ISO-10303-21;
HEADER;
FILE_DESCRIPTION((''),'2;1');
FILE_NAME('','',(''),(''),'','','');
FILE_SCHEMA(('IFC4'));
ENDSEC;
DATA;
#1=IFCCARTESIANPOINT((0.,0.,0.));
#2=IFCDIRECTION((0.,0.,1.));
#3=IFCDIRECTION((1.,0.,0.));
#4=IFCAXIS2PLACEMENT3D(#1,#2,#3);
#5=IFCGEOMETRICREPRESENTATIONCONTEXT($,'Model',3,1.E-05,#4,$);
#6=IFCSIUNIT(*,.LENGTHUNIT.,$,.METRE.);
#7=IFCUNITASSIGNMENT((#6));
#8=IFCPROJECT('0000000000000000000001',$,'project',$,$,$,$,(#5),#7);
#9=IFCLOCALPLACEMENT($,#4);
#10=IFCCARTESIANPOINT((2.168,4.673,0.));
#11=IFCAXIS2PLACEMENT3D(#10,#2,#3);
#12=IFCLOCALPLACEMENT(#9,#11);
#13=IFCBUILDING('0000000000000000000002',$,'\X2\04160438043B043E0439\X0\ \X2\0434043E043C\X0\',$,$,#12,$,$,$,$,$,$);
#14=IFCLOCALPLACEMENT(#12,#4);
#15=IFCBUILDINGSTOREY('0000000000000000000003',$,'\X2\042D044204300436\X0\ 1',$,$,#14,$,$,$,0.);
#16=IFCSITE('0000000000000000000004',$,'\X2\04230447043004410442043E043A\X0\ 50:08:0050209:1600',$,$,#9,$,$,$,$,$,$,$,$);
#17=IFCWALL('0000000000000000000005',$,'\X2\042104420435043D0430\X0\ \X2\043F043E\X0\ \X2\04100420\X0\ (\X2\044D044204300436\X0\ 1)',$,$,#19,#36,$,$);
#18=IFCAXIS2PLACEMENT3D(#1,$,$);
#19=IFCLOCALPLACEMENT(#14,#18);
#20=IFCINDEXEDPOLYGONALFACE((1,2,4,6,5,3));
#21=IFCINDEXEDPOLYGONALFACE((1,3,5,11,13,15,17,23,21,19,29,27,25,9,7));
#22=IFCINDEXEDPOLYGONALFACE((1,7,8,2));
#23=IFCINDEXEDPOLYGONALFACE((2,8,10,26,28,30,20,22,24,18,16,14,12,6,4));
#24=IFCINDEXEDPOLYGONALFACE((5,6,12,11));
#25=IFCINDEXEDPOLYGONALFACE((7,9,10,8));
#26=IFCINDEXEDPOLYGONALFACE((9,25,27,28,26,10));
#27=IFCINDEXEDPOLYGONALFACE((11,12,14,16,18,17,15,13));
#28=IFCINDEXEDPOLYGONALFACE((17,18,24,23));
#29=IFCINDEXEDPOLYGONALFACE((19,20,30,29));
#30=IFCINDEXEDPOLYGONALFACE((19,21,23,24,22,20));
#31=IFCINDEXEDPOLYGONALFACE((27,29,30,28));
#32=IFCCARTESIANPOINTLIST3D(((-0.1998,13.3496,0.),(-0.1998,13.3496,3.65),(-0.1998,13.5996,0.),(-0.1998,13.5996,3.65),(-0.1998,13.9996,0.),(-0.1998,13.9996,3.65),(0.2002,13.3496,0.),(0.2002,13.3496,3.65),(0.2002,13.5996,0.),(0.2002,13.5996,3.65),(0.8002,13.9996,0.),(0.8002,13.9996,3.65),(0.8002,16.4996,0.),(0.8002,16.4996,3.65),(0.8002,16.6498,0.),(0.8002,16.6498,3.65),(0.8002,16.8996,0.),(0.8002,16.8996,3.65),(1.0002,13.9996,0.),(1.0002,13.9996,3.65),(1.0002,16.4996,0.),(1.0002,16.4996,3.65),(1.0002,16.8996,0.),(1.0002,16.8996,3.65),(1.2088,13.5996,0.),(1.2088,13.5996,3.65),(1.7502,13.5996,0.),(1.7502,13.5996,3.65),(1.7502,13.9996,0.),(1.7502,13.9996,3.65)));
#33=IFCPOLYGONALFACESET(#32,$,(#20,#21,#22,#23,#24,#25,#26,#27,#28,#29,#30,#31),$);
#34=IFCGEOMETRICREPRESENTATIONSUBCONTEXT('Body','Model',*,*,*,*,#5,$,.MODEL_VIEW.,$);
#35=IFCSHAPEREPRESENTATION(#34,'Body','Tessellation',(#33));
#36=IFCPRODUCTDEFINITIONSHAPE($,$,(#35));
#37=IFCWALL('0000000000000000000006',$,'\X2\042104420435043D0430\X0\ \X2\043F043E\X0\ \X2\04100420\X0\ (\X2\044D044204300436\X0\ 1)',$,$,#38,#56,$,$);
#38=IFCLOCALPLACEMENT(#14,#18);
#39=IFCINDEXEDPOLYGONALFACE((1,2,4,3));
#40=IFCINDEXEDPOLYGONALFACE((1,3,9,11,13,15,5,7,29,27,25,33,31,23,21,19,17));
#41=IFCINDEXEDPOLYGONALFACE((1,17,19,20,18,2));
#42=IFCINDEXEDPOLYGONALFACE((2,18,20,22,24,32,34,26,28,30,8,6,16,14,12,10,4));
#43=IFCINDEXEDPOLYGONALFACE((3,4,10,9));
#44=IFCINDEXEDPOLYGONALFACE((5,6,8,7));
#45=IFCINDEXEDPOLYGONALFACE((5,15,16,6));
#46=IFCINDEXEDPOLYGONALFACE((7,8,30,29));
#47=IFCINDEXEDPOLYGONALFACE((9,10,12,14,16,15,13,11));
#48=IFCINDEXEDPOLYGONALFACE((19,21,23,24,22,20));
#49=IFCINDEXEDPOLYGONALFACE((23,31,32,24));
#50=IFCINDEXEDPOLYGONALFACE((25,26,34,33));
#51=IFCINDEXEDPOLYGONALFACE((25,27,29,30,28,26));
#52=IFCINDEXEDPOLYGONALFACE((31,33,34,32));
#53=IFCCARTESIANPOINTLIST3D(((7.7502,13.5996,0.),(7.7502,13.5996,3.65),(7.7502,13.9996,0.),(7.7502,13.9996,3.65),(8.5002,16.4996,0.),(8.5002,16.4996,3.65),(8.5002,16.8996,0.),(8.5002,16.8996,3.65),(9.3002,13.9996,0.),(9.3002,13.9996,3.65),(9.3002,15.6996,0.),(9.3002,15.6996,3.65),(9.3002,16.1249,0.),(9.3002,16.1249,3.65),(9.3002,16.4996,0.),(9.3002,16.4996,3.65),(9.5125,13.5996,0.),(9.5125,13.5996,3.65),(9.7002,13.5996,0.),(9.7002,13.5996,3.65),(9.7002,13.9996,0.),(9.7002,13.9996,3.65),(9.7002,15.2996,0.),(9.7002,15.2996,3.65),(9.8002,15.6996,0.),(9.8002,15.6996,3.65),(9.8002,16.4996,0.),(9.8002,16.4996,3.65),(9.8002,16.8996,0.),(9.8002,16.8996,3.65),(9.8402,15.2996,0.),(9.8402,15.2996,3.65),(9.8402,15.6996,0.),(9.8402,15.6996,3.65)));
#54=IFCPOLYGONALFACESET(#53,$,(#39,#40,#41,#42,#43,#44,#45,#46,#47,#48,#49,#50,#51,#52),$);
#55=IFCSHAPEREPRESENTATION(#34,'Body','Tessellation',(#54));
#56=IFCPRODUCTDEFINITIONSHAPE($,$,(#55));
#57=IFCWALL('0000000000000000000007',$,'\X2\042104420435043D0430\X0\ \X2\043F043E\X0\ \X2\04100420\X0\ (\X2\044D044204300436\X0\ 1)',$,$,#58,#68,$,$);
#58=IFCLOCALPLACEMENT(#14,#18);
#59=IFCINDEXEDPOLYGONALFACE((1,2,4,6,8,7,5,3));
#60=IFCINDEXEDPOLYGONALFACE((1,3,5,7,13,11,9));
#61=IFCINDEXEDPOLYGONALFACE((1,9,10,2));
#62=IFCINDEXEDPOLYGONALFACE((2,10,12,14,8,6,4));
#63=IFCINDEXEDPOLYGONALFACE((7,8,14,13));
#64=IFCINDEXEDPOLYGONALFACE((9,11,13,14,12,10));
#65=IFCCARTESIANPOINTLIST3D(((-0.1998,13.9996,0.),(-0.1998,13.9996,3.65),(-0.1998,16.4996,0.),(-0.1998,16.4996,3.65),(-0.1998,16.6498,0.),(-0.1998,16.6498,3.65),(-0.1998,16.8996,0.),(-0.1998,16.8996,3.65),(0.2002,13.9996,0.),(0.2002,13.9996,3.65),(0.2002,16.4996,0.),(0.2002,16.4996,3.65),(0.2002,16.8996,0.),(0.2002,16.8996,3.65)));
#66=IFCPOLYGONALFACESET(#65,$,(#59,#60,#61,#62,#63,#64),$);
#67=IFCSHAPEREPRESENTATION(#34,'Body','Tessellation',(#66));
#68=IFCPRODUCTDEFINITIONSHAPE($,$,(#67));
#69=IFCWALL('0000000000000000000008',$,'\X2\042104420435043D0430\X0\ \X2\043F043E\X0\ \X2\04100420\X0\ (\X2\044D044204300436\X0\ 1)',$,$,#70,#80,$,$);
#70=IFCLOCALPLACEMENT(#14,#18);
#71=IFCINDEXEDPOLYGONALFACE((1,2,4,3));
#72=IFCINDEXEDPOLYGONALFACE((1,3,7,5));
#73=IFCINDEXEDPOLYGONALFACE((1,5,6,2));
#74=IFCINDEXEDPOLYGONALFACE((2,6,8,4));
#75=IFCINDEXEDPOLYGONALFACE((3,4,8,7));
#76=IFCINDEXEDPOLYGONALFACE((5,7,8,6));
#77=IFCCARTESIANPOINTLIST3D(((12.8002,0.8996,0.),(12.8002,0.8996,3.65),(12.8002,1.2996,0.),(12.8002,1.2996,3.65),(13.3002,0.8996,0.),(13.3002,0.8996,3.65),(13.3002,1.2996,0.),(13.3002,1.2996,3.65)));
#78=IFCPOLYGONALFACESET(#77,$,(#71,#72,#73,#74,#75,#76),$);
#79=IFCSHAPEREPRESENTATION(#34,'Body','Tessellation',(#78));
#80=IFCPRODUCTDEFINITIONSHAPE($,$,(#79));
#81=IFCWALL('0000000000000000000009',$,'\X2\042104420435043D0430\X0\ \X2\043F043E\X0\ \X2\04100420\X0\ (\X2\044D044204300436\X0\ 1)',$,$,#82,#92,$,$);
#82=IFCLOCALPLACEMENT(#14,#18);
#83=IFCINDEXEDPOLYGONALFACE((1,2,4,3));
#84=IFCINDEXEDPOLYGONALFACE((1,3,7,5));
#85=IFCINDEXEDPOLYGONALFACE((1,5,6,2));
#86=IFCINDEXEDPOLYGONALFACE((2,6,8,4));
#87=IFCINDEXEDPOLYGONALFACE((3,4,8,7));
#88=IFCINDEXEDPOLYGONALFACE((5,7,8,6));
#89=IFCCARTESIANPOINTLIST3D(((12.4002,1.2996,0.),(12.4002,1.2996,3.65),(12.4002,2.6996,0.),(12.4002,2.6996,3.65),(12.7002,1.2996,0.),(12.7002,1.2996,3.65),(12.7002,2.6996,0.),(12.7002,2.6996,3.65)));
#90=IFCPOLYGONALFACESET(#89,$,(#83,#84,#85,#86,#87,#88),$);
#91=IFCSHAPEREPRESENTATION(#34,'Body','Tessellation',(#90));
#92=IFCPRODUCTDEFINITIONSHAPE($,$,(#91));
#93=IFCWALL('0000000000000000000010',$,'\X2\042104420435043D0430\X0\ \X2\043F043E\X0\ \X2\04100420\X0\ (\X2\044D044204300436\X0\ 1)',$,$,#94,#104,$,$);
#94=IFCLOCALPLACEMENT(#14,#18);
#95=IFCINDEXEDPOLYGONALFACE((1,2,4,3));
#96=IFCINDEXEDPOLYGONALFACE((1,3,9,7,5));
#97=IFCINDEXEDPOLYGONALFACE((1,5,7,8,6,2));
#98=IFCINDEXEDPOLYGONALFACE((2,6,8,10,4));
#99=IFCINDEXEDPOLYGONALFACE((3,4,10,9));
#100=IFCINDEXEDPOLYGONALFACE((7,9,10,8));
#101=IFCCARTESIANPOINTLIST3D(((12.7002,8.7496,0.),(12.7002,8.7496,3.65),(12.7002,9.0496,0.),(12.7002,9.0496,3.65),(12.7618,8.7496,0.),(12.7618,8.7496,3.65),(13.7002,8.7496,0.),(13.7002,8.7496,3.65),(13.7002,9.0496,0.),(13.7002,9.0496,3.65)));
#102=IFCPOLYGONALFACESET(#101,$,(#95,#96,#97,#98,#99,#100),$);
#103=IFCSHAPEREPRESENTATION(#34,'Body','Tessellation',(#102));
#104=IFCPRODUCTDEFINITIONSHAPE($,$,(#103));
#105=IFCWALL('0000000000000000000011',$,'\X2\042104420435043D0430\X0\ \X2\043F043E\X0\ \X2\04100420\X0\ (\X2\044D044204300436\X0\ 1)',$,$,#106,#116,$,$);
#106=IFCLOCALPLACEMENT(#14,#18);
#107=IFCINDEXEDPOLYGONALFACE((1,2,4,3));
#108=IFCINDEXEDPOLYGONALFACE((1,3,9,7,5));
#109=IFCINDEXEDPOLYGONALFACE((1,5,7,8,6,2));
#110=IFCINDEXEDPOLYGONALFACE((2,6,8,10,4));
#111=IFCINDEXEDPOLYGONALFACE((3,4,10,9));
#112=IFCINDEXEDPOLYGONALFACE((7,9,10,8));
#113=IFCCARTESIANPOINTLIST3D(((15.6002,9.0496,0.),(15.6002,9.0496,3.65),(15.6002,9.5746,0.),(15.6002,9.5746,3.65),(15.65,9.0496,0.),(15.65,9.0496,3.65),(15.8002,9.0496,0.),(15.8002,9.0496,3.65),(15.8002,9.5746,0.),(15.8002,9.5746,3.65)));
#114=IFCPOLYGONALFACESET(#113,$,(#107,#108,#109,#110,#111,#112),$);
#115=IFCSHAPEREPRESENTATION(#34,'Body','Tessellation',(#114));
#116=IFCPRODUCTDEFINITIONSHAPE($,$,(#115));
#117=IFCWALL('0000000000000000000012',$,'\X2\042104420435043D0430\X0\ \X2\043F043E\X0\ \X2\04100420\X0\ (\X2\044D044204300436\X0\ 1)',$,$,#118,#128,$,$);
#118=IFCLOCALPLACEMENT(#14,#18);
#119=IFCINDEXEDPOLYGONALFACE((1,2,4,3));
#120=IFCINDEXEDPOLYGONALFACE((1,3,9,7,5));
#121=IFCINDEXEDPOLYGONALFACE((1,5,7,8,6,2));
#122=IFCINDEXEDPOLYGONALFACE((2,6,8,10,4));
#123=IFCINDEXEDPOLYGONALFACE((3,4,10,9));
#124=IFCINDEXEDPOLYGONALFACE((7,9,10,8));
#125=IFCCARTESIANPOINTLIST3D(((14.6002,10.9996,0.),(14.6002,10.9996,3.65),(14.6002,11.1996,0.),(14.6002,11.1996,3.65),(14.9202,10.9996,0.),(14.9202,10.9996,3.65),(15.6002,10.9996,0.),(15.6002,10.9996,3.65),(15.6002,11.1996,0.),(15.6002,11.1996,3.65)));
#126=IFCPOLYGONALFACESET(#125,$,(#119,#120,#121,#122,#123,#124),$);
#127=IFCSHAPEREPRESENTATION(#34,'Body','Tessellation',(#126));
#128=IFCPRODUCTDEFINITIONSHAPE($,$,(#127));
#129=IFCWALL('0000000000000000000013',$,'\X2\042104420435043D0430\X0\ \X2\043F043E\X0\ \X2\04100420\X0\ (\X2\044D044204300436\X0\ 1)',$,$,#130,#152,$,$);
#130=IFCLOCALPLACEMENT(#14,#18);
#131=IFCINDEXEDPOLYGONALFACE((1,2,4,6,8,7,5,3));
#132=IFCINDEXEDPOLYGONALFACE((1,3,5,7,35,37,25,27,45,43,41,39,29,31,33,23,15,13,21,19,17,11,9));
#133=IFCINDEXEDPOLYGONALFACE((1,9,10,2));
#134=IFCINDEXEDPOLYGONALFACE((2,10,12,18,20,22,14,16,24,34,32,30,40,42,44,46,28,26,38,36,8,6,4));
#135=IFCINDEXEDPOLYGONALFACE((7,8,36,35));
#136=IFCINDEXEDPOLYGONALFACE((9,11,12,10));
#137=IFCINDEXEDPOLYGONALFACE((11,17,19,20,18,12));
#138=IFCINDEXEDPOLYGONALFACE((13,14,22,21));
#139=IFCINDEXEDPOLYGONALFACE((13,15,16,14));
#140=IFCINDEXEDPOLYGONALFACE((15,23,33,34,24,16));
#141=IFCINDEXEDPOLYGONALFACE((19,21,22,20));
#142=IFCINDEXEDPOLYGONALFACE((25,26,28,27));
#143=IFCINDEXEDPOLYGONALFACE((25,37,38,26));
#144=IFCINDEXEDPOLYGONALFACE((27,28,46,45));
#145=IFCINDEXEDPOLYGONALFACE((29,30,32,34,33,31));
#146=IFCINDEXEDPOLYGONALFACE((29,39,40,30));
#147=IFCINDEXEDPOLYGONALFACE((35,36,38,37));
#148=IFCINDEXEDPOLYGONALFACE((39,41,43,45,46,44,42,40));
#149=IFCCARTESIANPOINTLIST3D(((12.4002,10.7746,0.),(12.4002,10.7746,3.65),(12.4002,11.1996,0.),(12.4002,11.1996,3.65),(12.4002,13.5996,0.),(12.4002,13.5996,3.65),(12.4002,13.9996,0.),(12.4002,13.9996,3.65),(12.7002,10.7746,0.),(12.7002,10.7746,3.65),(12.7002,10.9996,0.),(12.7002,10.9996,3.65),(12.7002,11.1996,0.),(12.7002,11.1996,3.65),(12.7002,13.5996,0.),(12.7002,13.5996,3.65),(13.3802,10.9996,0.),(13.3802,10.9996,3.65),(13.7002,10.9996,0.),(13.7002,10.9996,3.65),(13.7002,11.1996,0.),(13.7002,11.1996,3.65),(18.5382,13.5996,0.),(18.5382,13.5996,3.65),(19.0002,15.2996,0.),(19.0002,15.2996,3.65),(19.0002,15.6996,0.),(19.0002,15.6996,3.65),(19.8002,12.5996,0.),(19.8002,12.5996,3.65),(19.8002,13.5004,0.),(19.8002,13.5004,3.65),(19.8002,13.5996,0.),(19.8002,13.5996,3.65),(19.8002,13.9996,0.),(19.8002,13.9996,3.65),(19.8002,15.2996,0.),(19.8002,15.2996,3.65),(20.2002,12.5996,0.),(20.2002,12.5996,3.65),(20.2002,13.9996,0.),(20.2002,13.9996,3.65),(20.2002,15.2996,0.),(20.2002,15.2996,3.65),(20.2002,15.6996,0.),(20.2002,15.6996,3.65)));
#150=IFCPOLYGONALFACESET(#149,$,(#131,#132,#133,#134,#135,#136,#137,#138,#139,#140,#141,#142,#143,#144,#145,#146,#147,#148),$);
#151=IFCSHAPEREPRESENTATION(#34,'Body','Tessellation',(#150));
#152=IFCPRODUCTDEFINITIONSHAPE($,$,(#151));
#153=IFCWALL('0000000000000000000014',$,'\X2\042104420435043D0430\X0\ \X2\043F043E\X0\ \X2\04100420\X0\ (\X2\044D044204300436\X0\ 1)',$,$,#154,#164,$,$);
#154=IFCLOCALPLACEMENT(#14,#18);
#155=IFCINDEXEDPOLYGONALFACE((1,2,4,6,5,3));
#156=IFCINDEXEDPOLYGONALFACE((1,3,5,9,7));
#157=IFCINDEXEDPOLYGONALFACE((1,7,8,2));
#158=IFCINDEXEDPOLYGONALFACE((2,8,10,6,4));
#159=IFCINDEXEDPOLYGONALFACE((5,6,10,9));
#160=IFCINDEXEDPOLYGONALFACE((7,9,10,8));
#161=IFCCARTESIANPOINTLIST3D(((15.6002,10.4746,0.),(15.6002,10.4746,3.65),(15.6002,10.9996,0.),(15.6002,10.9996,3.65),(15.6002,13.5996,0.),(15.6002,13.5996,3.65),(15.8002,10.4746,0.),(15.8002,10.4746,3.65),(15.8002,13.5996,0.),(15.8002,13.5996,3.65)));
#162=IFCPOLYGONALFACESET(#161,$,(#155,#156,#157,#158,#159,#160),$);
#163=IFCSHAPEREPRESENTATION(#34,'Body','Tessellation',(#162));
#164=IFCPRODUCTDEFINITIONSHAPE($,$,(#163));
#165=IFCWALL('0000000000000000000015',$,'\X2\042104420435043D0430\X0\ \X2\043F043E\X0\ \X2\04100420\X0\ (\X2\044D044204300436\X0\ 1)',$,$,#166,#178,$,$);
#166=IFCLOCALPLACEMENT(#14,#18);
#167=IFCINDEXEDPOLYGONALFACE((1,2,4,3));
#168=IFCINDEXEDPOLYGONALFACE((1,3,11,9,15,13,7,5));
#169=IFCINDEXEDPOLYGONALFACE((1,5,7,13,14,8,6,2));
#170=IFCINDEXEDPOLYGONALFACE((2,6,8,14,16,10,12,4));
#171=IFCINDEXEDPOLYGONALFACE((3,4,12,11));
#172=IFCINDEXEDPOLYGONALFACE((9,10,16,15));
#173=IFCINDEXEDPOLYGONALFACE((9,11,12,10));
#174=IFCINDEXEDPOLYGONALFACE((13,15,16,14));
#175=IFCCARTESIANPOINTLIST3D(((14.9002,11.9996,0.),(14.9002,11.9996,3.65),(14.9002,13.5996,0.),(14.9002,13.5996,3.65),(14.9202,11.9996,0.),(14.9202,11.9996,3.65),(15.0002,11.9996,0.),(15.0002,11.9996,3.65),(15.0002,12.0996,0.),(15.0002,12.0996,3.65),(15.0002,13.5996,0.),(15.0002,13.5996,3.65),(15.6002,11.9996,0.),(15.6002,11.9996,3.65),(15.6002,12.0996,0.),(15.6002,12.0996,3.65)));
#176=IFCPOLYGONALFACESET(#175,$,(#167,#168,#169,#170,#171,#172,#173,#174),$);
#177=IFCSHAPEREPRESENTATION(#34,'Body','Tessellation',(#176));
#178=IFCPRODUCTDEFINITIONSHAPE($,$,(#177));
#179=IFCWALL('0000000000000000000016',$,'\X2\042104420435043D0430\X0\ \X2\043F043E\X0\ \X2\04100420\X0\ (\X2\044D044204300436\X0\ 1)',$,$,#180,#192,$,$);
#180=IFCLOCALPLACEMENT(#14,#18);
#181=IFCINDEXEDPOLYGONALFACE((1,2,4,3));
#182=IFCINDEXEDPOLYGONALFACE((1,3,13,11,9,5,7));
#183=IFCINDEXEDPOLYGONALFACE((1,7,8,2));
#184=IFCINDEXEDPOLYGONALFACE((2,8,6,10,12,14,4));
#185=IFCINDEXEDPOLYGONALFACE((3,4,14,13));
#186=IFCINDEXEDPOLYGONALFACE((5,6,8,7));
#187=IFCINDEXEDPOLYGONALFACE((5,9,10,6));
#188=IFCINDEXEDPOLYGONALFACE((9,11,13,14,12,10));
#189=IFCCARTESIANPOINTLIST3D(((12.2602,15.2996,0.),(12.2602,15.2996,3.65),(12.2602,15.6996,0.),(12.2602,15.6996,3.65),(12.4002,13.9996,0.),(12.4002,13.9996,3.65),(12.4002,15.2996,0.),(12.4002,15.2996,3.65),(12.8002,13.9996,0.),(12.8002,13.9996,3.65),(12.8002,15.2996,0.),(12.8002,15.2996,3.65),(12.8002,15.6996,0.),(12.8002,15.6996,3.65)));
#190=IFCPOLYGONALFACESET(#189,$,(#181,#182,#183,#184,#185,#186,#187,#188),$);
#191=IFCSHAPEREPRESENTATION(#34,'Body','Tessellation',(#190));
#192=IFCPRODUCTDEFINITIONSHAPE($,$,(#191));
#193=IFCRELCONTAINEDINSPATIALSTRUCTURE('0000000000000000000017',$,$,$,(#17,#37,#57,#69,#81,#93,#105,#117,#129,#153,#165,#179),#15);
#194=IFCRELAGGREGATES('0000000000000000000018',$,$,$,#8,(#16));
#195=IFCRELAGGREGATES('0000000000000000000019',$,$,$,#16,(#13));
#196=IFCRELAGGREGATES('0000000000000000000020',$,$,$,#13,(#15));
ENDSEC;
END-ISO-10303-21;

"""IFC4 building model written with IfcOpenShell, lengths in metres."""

from ifc_helpers import new_model, si_unit, frame, origin_with_axes, place, context, subcontext, project, spatial, polyline, outline, extrude, element, save


model = new_model("IFC4")

# Units and contexts
model_context = context("Model", 3, precision=1e-05, world=origin_with_axes())
body_context = subcontext(model_context, "Body", "Model", "MODEL_VIEW")
ifc_project = project(units=[si_unit("LENGTHUNIT", "METRE")], contexts=[model_context])

# Site, building, storey
site_placement = place(None, origin_with_axes())
site = spatial("IfcSite", under=ifc_project, at=site_placement, Name="Участок 50:08:0050209:1600")
building_placement = place(site_placement, frame((2.168, 4.673, 0.0), z_axis=(0.0, 0.0, 1.0), x_axis=(1.0, 0.0, 0.0)))
building = spatial("IfcBuilding", under=site, at=building_placement, Name="Жилой дом")
storey_placement = place(building_placement, origin_with_axes())
storey = spatial("IfcBuildingStorey", under=building, at=storey_placement, Name="Этаж 1", Elevation=0.0)

# Walls
wall_1_placement = place(storey_placement, origin_with_axes())
element("IfcWall", 1, at=wall_1_placement, inside=storey, Name="Стена по АР (этаж 1)", context=body_context, shape_type="SweptSolid", body=[
    extrude(outline(polyline([(1.2088, 13.5996), (0.2002, 13.5996), (0.2002, 13.3496), (-0.1998, 13.3496), (-0.1998, 13.5996), (-0.1998, 13.9996), (0.8002, 13.9996), (0.8002, 16.4996), (0.8002, 16.6498), (0.8002, 16.8996), (1.0002, 16.8996), (1.0002, 16.4996), (1.0002, 13.9996), (1.7502, 13.9996), (1.7502, 13.5996), (1.2088, 13.5996)])), origin_with_axes(), (0.0, 0.0, 1.0), 3.65),
])
wall_2_placement = place(storey_placement, origin_with_axes())
element("IfcWall", 2, at=wall_2_placement, inside=storey, Name="Стена по АР (этаж 1)", context=body_context, shape_type="SweptSolid", body=[
    extrude(outline(polyline([(7.7502, 13.5996), (7.7502, 13.9996), (9.3002, 13.9996), (9.3002, 15.6996), (9.3002, 16.1249), (9.3002, 16.4996), (8.5002, 16.4996), (8.5002, 16.8996), (9.8002, 16.8996), (9.8002, 16.4996), (9.8002, 15.6996), (9.8402, 15.6996), (9.8402, 15.2996), (9.7002, 15.2996), (9.7002, 15.5696), (9.7002, 15.6996), (9.7002, 15.6996), (9.7002, 13.9996), (9.7002, 13.9996), (9.7002, 13.5996), (9.5125, 13.5996), (7.7502, 13.5996)])), origin_with_axes(), (0.0, 0.0, 1.0), 3.65),
])
wall_3_placement = place(storey_placement, origin_with_axes())
element("IfcWall", 3, at=wall_3_placement, inside=storey, Name="Стена по АР (этаж 1)", context=body_context, shape_type="SweptSolid", body=[
    extrude(outline(polyline([(-0.1998, 16.6498), (-0.1998, 16.8996), (0.2002, 16.8996), (0.2002, 16.4996), (0.2002, 16.4996), (0.2002, 13.9996), (-0.1998, 13.9996), (-0.1998, 13.9996), (-0.1998, 16.4996), (-0.1998, 16.6498)])), origin_with_axes(), (0.0, 0.0, 1.0), 3.65),
])
wall_4_placement = place(storey_placement, origin_with_axes())
element("IfcWall", 4, at=wall_4_placement, inside=storey, Name="Стена по АР (этаж 1)", context=body_context, shape_type="SweptSolid", body=[
    extrude(outline(polyline([(12.8002, 1.2996), (13.3002, 1.2996), (13.3002, 0.8996), (12.8002, 0.8996), (12.8002, 1.2996)])), origin_with_axes(), (0.0, 0.0, 1.0), 3.65),
])
wall_5_placement = place(storey_placement, origin_with_axes())
element("IfcWall", 5, at=wall_5_placement, inside=storey, Name="Стена по АР (этаж 1)", context=body_context, shape_type="SweptSolid", body=[
    extrude(outline(polyline([(12.4002, 2.6996), (12.7002, 2.6996), (12.7002, 1.2996), (12.4002, 1.2996), (12.4002, 2.6996)])), origin_with_axes(), (0.0, 0.0, 1.0), 3.65),
])
wall_6_placement = place(storey_placement, origin_with_axes())
element("IfcWall", 6, at=wall_6_placement, inside=storey, Name="Стена по АР (этаж 1)", context=body_context, shape_type="SweptSolid", body=[
    extrude(outline(polyline([(12.7002, 8.7496), (12.7002, 9.0496), (13.7002, 9.0496), (13.7002, 8.7496), (12.7618, 8.7496), (12.7002, 8.7496)])), origin_with_axes(), (0.0, 0.0, 1.0), 3.65),
])
wall_7_placement = place(storey_placement, origin_with_axes())
element("IfcWall", 7, at=wall_7_placement, inside=storey, Name="Стена по АР (этаж 1)", context=body_context, shape_type="SweptSolid", body=[
    extrude(outline(polyline([(15.6002, 9.0496), (15.6002, 9.5746), (15.8002, 9.5746), (15.8002, 9.0496), (15.65, 9.0496), (15.6002, 9.0496)])), origin_with_axes(), (0.0, 0.0, 1.0), 3.65),
])
wall_8_placement = place(storey_placement, origin_with_axes())
element("IfcWall", 8, at=wall_8_placement, inside=storey, Name="Стена по АР (этаж 1)", context=body_context, shape_type="SweptSolid", body=[
    extrude(outline(polyline([(14.9202, 10.9996), (14.6002, 10.9996), (14.6002, 11.1996), (15.6002, 11.1996), (15.6002, 10.9996), (14.9202, 10.9996)])), origin_with_axes(), (0.0, 0.0, 1.0), 3.65),
])
wall_9_placement = place(storey_placement, origin_with_axes())
element("IfcWall", 9, at=wall_9_placement, inside=storey, Name="Стена по АР (этаж 1)", context=body_context, shape_type="SweptSolid", body=[
    extrude(outline(polyline([(12.7002, 10.7746), (12.4002, 10.7746), (12.4002, 11.1996), (12.4002, 13.5996), (12.4002, 13.5996), (12.4002, 13.9996), (19.8002, 13.9996), (19.8002, 15.2996), (19.0002, 15.2996), (19.0002, 15.6996), (20.2002, 15.6996), (20.2002, 15.2996), (20.2002, 13.9996), (20.2002, 12.5996), (19.8002, 12.5996), (19.8002, 13.5004), (19.8002, 13.5996), (18.5382, 13.5996), (12.7002, 13.5996), (12.7002, 11.1996), (13.7002, 11.1996), (13.7002, 10.9996), (13.3802, 10.9996), (12.7002, 10.9996), (12.7002, 10.7746)])), origin_with_axes(), (0.0, 0.0, 1.0), 3.65),
])
wall_10_placement = place(storey_placement, origin_with_axes())
element("IfcWall", 10, at=wall_10_placement, inside=storey, Name="Стена по АР (этаж 1)", context=body_context, shape_type="SweptSolid", body=[
    extrude(outline(polyline([(15.6002, 13.5996), (15.8002, 13.5996), (15.8002, 10.4746), (15.6002, 10.4746), (15.6002, 10.9996), (15.6002, 13.5996)])), origin_with_axes(), (0.0, 0.0, 1.0), 3.65),
])
wall_11_placement = place(storey_placement, origin_with_axes())
element("IfcWall", 11, at=wall_11_placement, inside=storey, Name="Стена по АР (этаж 1)", context=body_context, shape_type="SweptSolid", body=[
    extrude(outline(polyline([(14.9002, 13.5996), (15.0002, 13.5996), (15.0002, 12.0996), (15.6002, 12.0996), (15.6002, 11.9996), (15.0002, 11.9996), (14.9202, 11.9996), (14.9002, 11.9996), (14.9002, 13.5996)])), origin_with_axes(), (0.0, 0.0, 1.0), 3.65),
])
wall_12_placement = place(storey_placement, origin_with_axes())
element("IfcWall", 12, at=wall_12_placement, inside=storey, Name="Стена по АР (этаж 1)", context=body_context, shape_type="SweptSolid", body=[
    extrude(outline(polyline([(12.2602, 15.2996), (12.2602, 15.6996), (12.8002, 15.6996), (12.8002, 15.2996), (12.8002, 13.9996), (12.4002, 13.9996), (12.4002, 15.2996), (12.2602, 15.2996)])), origin_with_axes(), (0.0, 0.0, 1.0), 3.65),
])

save(model, "model.ifc")
